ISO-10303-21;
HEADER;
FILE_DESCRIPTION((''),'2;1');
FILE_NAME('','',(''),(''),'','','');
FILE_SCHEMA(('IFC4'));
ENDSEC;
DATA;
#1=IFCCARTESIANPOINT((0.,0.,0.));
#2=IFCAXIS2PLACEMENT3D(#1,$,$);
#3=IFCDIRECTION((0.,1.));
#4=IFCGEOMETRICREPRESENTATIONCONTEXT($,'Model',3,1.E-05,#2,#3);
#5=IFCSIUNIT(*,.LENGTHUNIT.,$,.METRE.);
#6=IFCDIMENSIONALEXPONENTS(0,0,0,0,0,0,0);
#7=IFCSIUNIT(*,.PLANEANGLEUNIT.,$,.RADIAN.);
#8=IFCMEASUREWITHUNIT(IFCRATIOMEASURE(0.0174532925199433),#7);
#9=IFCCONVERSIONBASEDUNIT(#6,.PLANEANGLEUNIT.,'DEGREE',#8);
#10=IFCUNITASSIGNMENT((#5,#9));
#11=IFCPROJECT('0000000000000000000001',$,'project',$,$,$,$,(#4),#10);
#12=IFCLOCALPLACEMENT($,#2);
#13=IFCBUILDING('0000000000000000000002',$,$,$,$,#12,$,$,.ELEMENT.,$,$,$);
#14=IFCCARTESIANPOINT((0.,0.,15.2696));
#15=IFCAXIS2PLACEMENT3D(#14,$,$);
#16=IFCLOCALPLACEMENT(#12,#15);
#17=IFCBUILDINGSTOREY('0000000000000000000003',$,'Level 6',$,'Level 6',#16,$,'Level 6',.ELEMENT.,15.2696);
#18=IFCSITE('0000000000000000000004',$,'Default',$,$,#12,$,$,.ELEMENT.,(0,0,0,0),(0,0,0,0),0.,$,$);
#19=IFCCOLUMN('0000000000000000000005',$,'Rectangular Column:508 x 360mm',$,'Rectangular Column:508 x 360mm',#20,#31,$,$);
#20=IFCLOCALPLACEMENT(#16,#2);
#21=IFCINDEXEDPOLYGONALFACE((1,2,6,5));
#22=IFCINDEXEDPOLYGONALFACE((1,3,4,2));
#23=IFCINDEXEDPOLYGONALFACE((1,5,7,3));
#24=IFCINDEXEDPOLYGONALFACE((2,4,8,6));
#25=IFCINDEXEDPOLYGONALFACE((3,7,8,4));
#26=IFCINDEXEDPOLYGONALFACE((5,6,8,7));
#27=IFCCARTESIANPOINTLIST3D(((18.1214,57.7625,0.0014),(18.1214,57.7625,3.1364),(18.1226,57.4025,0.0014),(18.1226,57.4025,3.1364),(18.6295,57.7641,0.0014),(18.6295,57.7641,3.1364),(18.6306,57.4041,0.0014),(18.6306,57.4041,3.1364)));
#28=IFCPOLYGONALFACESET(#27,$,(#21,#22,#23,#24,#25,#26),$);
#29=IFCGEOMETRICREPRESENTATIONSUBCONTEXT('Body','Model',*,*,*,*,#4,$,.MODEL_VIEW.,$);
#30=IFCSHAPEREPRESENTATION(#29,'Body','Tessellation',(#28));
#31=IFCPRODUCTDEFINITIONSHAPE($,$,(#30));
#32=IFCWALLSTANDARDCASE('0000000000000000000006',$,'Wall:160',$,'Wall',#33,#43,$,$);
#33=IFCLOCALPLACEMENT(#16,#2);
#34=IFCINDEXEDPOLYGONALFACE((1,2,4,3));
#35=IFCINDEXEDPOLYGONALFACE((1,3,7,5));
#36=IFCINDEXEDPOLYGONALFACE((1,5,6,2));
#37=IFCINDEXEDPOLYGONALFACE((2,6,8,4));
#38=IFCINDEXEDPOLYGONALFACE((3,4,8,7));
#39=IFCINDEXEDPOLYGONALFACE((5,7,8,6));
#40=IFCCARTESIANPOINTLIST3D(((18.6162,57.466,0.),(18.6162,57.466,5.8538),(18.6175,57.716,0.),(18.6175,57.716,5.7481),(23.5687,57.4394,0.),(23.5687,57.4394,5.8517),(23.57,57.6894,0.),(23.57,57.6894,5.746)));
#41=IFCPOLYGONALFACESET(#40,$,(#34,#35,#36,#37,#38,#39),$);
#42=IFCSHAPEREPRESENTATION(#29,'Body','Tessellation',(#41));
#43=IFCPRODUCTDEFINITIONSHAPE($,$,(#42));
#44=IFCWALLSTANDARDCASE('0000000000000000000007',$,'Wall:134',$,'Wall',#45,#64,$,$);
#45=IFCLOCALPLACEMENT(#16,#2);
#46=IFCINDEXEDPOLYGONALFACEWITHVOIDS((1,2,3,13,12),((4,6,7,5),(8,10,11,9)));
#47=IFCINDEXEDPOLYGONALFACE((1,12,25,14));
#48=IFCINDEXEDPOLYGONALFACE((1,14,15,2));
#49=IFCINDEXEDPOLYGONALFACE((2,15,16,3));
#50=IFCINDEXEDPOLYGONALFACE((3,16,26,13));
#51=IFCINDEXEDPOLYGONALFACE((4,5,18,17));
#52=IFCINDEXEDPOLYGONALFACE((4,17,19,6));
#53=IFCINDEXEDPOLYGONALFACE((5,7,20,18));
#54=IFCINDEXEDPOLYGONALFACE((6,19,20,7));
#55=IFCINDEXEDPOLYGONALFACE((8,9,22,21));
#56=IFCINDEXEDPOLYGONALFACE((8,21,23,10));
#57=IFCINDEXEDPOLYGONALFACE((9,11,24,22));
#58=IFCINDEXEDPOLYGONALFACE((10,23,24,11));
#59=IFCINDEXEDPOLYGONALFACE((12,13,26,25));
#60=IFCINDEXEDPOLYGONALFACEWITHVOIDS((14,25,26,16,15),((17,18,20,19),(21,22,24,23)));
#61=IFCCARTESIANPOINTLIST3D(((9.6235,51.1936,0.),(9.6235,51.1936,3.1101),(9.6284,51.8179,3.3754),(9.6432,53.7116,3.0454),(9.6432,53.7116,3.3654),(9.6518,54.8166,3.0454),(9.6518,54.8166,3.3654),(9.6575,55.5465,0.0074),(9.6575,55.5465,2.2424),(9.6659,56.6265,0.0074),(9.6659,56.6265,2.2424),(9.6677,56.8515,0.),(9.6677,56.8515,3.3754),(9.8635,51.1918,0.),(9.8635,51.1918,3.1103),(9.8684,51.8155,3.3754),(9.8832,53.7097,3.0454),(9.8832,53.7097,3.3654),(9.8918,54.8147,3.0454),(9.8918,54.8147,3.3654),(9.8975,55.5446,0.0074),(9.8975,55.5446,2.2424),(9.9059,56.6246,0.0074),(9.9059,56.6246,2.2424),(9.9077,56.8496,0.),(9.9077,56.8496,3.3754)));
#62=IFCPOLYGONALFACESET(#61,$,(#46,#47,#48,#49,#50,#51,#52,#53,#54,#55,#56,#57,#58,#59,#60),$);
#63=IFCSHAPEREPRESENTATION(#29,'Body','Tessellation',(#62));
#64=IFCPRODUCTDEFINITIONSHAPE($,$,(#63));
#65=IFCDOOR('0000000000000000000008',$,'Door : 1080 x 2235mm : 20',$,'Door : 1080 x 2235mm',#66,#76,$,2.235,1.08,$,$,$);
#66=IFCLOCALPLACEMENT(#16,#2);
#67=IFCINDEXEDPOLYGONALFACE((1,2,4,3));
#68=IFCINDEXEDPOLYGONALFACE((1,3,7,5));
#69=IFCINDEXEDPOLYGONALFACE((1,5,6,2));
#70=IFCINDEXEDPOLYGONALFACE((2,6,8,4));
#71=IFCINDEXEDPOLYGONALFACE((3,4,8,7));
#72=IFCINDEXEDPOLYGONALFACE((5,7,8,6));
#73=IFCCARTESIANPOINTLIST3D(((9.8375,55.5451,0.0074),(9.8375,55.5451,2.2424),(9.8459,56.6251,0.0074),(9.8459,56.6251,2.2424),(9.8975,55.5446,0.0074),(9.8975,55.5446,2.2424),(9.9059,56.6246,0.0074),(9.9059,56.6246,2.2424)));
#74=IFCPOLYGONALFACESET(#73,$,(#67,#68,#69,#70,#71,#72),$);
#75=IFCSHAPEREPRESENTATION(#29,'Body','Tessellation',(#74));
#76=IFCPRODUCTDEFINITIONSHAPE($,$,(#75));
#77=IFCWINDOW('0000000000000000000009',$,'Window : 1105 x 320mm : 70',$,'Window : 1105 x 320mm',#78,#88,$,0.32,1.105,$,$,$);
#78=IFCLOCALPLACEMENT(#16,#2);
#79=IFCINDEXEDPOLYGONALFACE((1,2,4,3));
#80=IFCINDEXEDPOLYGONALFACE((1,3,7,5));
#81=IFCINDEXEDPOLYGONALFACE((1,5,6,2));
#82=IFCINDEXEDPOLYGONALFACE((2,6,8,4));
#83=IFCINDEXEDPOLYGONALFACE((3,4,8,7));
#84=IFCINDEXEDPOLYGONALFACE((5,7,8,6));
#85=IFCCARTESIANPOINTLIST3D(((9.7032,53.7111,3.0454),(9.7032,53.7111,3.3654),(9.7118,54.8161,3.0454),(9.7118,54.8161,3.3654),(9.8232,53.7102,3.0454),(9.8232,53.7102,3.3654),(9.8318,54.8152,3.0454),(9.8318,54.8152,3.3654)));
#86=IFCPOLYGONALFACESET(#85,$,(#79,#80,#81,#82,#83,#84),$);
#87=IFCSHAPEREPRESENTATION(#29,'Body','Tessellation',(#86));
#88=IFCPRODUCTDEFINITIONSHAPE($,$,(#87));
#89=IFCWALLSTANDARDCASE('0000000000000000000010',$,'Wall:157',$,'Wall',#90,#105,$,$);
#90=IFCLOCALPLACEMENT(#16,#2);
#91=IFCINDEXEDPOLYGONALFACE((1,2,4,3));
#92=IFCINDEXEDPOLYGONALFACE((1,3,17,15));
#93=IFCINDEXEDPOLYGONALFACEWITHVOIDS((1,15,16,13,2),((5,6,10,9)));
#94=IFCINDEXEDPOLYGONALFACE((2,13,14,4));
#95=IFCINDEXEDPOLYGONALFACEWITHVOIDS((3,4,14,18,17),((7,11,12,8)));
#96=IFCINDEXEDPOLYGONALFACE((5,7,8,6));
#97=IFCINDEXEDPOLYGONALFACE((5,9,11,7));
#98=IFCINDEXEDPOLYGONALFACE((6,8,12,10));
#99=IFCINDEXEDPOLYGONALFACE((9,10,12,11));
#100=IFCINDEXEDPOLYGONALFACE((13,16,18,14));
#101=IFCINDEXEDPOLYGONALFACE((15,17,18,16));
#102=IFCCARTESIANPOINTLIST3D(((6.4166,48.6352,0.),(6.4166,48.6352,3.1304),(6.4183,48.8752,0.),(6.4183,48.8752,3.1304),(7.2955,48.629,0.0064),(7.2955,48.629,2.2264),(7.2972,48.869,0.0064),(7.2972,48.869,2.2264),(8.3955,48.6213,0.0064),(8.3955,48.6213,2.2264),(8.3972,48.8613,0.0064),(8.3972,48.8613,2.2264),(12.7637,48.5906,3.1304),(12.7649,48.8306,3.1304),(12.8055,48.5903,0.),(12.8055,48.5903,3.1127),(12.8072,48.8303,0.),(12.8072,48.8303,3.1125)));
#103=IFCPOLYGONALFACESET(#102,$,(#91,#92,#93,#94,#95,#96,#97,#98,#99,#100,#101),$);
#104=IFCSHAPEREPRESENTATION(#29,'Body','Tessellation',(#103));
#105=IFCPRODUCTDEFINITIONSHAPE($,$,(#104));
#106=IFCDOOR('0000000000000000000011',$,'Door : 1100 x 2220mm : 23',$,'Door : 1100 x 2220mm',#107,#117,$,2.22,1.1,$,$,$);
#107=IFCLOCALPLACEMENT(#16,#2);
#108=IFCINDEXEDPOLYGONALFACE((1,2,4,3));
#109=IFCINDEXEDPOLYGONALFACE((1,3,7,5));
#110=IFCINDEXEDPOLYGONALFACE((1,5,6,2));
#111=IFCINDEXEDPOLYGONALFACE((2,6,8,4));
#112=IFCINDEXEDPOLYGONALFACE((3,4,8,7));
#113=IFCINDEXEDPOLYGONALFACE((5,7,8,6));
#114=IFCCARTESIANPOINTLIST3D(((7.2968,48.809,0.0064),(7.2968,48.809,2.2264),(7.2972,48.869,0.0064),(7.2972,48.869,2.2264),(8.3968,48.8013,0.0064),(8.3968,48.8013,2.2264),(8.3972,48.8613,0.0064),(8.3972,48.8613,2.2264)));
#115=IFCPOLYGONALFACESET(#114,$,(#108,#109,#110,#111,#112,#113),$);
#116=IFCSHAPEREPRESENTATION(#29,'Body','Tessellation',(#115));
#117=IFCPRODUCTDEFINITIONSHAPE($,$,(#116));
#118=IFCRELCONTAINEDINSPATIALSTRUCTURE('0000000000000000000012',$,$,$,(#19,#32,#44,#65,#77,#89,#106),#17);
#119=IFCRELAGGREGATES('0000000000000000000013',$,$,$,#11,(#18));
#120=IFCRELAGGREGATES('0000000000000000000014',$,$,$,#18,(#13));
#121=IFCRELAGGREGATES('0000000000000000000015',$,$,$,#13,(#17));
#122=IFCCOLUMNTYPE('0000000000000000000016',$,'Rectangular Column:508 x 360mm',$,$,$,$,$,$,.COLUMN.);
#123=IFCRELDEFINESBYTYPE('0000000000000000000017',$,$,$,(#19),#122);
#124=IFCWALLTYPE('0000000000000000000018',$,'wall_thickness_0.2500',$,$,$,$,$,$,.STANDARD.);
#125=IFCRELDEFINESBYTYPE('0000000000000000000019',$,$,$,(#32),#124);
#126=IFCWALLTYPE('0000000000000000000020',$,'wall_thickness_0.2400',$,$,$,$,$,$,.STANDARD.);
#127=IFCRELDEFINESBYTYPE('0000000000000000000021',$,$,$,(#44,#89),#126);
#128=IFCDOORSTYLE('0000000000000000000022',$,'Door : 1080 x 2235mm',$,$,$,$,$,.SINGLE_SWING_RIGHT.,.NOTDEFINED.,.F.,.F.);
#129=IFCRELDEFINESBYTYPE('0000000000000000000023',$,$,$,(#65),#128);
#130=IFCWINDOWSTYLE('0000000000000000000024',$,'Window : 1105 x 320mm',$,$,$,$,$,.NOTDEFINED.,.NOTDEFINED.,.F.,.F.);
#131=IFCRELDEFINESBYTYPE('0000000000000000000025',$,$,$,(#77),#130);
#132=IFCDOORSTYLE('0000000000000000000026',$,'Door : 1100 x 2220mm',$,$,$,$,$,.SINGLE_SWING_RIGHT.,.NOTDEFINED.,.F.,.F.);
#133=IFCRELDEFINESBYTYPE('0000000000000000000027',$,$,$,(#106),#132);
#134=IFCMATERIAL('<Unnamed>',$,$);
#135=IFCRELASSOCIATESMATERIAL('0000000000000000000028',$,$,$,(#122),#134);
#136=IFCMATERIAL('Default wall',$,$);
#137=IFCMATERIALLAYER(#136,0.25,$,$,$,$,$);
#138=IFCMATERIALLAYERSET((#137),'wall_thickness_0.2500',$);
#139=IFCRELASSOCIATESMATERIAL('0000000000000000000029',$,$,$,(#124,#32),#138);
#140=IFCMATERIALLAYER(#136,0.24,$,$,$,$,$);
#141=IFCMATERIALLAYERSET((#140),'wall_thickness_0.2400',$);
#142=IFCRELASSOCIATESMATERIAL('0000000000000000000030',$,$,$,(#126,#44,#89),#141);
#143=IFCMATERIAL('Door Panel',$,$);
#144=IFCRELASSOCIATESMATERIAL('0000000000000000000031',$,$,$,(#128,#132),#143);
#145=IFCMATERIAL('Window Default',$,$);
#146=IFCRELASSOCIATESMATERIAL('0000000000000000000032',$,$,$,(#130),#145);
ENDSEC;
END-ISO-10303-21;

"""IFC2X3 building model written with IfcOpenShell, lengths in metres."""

from ifc_helpers import new_model, entity, si_unit, converted_unit, direction, frame, frame_2d, origin, origin_2d_with_axis, place, context, subcontext, project, spatial, polyline, rectangle, outline, extrude, clip, halfspace, source, transform, mapped, material, layer, layer_set, layer_usage, type_object, type_shapes, element, fill, save


model = new_model("IFC2X3")

# Units and contexts
model_context = context("Model", 3, precision=1e-05, world=origin(), true_north=direction((0.0, 1.0)))
body_context = subcontext(model_context, "Body", "Model", "MODEL_VIEW")
ifc_project = project(units=[si_unit("LENGTHUNIT", "METRE"), converted_unit("PLANEANGLEUNIT", "DEGREE", entity("IfcRatioMeasure", 0.0174532925199433), si_unit("PLANEANGLEUNIT", "RADIAN"), dimensions=[0, 0, 0, 0, 0, 0, 0])], contexts=[model_context])

# Site, building, storey
placement = place(None, origin())
site = spatial("IfcSite", under=ifc_project, at=placement, Name="Default", CompositionType="ELEMENT", RefLatitude=(0, 0, 0, 0), RefLongitude=(0, 0, 0, 0), RefElevation=0.0)
building = spatial("IfcBuilding", under=site, at=placement, CompositionType="ELEMENT")
storey_placement = place(placement, frame((0.0, 0.0, 15.2696)))
storey = spatial("IfcBuildingStorey", under=building, at=storey_placement, Name="Level 6", ObjectType="Level 6", LongName="Level 6", CompositionType="ELEMENT", Elevation=15.2696)

# Column
ifc_material_1 = material(Name="<Unnamed>")
column_type = type_object("IfcColumnType", Name="Rectangular Column:508 x 360mm", PredefinedType="COLUMN", material=ifc_material_1)
shared_shape_1 = source(origin(), body_context, "Body", "SweptSolid", [
    extrude(rectangle(XDim=0.508, YDim=0.36, at=origin_2d_with_axis()), frame((0.0, 0.0, 0.0), z_axis=(0.0, 0.0, 1.0), x_axis=(0.0, -1.0, 0.0)), (0.0, 0.0, 1.0), 3.135),
])
type_shapes(column_type, [shared_shape_1])
column_placement = place(placement, frame((18.376, 57.5833, 15.271), z_axis=(0.0, 0.0, 1.0), x_axis=(0.003112, -0.999995, 0.0)))
element("IfcColumn", 1, at=column_placement, inside=storey, type_object=column_type, Name="Rectangular Column:508 x 360mm", ObjectType="Rectangular Column:508 x 360mm", context=body_context, shape_type="MappedRepresentation", body=[
    mapped(shared_shape_1, transform((0.0, 0.0, 0.0), scale=1.0)),
])

# Wall
ifc_material_2 = material(Name="Default wall")
ifc_layer_1 = layer(ifc_material_2, 0.25)
ifc_layer_set_1 = layer_set([ifc_layer_1], Name="wall_thickness_0.2500")
ifc_layer_usage_1 = layer_usage(ifc_layer_set_1, "AXIS2", "POSITIVE", -0.125)
wall_type_1 = type_object("IfcWallType", Name="wall_thickness_0.2500", PredefinedType="STANDARD", material=ifc_layer_set_1)
wall_1_placement = place(storey_placement, frame((18.6169, 57.591, 0.0), z_axis=(0.0, 0.0, 1.0), x_axis=(0.999986, -0.005353, 0.0)))
element("IfcWallStandardCase", 2, at=wall_1_placement, inside=storey, type_object=wall_type_1, material=ifc_layer_usage_1, Name="Wall:160", ObjectType="Wall", context=body_context, shape_type="Clipping", body=[
    clip(extrude(outline(polyline([(4.9525, -0.125), (4.9525, 0.125), (0.0, 0.125), (0.0, -0.125), (4.9525, -0.125)])), origin(), (0.0, 0.0, 1.0), 6.0254), halfspace(frame((6.0103, -0.0562, 5.8222), z_axis=(0.000388, 0.389455, 0.921045), x_axis=(-0.999996, 0.002797, -0.000761)), False)),
])

# Wall, openings, door, window
ifc_layer_2 = layer(ifc_material_2, 0.24)
ifc_layer_set_2 = layer_set([ifc_layer_2], Name="wall_thickness_0.2400")
ifc_layer_usage_2 = layer_usage(ifc_layer_set_2, "AXIS2", "POSITIVE", -0.12)
wall_type_2 = type_object("IfcWallType", Name="wall_thickness_0.2400", PredefinedType="STANDARD", material=ifc_layer_set_2)
wall_2_placement = place(storey_placement, frame((9.7877, 56.8505, 0.0), z_axis=(0.0, 0.0, 1.0), x_axis=(-0.007798, -0.99997, 0.0)))
wall_2 = element("IfcWallStandardCase", 3, at=wall_2_placement, inside=storey, type_object=wall_type_2, material=ifc_layer_usage_2, Name="Wall:134", ObjectType="Wall", context=body_context, shape_type="Clipping", body=[
    clip(clip(extrude(outline(polyline([(5.658, -0.12), (5.658, 0.12), (0.0, 0.12), (0.0, -0.12), (5.658, -0.12)])), origin(), (0.0, 0.0, 1.0), 3.3754), halfspace(frame((-0.7809, -22.5476, 5.8261), z_axis=(0.391129, -0.000838, 0.920336), x_axis=(0.000352, 1.0, 0.000761)), False)), halfspace(frame((-20.4091, 2.8698, 3.1673), z_axis=(-0.001142, 0.390498, 0.920603), x_axis=(0.675569, -0.678456, 0.288623)), False)),
])
opening_1_placement = place(wall_2_placement, frame((0.225, -0.12, 0.0074)))
opening_1 = element("IfcOpeningElement", 4, at=opening_1_placement, cuts=wall_2, ObjectType="Opening", context=body_context, shape_type="SweptSolid", body=[
    extrude(rectangle(XDim=1.08, YDim=2.235, at=frame_2d((1.1175, 0.54), x_axis=(0.0, 1.0))), frame((0.0, 0.0, 0.0), z_axis=(0.0, 1.0, 0.0), x_axis=(0.0, 0.0, 1.0)), (0.0, 0.0, 1.0), 0.24),
])
opening_2_placement = place(wall_2_placement, frame((2.035, -0.12, 3.0454)))
opening_2 = element("IfcOpeningElement", 5, at=opening_2_placement, cuts=wall_2, ObjectType="Opening", context=body_context, shape_type="SweptSolid", body=[
    extrude(rectangle(XDim=1.105, YDim=0.32, at=frame_2d((0.16, 0.5525), x_axis=(0.0, 1.0))), frame((0.0, 0.0, 0.0), z_axis=(0.0, 1.0, 0.0), x_axis=(0.0, 0.0, 1.0)), (0.0, 0.0, 1.0), 0.24),
])
ifc_material_3 = material(Name="Door Panel")
door_style_1 = type_object("IfcDoorStyle", Name="Door : 1080 x 2235mm", ConstructionType="NOTDEFINED", OperationType="SINGLE_SWING_RIGHT", ParameterTakesPrecedence=False, Sizeable=False, material=ifc_material_3)
shared_shape_2 = source(origin(), body_context, "Body", "SweptSolid", [
    extrude(rectangle(XDim=0.06, YDim=1.08, at=origin_2d_with_axis()), frame((0.54, 0.21, 0.0), z_axis=(0.0, 0.0, 1.0), x_axis=(0.0, 1.0, 0.0)), (0.0, 0.0, 1.0), 2.235),
])
type_shapes(door_style_1, [shared_shape_2])
door_1_placement = place(opening_1_placement, origin())
door_1 = element("IfcDoor", 6, at=door_1_placement, inside=storey, type_object=door_style_1, Name="Door : 1080 x 2235mm : 20", ObjectType="Door : 1080 x 2235mm", OverallHeight=2.235, OverallWidth=1.08, context=body_context, shape_type="MappedRepresentation", body=[
    mapped(shared_shape_2, transform((0.0, 0.0, 0.0), scale=1.0)),
])
fill(opening_1, door_1)
ifc_material_4 = material(Name="Window Default")
window_style_1 = type_object("IfcWindowStyle", Name="Window : 1105 x 320mm", ConstructionType="NOTDEFINED", OperationType="NOTDEFINED", ParameterTakesPrecedence=False, Sizeable=False, material=ifc_material_4)
shared_shape_3 = source(origin(), body_context, "Body", "SweptSolid", [
    extrude(rectangle(XDim=0.12, YDim=1.105, at=origin_2d_with_axis()), frame((0.5525, 0.12, 0.0), z_axis=(0.0, 0.0, 1.0), x_axis=(0.0, 1.0, 0.0)), (0.0, 0.0, 1.0), 0.32),
])
type_shapes(window_style_1, [shared_shape_3])
window_1_placement = place(opening_2_placement, origin())
window_1 = element("IfcWindow", 7, at=window_1_placement, inside=storey, type_object=window_style_1, Name="Window : 1105 x 320mm : 70", ObjectType="Window : 1105 x 320mm", OverallHeight=0.32, OverallWidth=1.105, context=body_context, shape_type="MappedRepresentation", body=[
    mapped(shared_shape_3, transform((0.0, 0.0, 0.0), scale=1.0)),
])
fill(opening_2, window_1)

# Wall, opening, door
wall_3_placement = place(storey_placement, frame((6.4174, 48.7552, 0.0), z_axis=(0.0, 0.0, 1.0), x_axis=(0.999975, -0.007028, 0.0)))
wall_3 = element("IfcWallStandardCase", 8, at=wall_3_placement, inside=storey, type_object=wall_type_2, material=ifc_layer_usage_2, Name="Wall:157", ObjectType="Wall", context=body_context, shape_type="Clipping", body=[
    clip(extrude(outline(polyline([(6.3891, -0.12), (6.3891, 0.12), (0.0, 0.12), (0.0, -0.12), (6.3891, -0.12)])), origin(), (0.0, 0.0, 1.0), 3.1304), halfspace(frame((6.1988, 28.5257, 3.1673), z_axis=(0.390499, 0.000841, 0.920603), x_axis=(-0.678976, -0.675046, 0.288623)), False)),
])
opening_3_placement = place(wall_3_placement, frame((0.879, -0.12, 0.0064)))
opening_3 = element("IfcOpeningElement", 9, at=opening_3_placement, cuts=wall_3, ObjectType="Opening", context=body_context, shape_type="SweptSolid", body=[
    extrude(rectangle(XDim=1.1, YDim=2.22, at=frame_2d((1.11, 0.55), x_axis=(0.0, 1.0))), frame((0.0, 0.0, 0.0), z_axis=(0.0, 1.0, 0.0), x_axis=(0.0, 0.0, 1.0)), (0.0, 0.0, 1.0), 0.24),
])
door_style_2 = type_object("IfcDoorStyle", Name="Door : 1100 x 2220mm", ConstructionType="NOTDEFINED", OperationType="SINGLE_SWING_RIGHT", ParameterTakesPrecedence=False, Sizeable=False, material=ifc_material_3)
shared_shape_4 = source(origin(), body_context, "Body", "SweptSolid", [
    extrude(rectangle(XDim=0.06, YDim=1.1, at=origin_2d_with_axis()), frame((0.55, 0.21, 0.0), z_axis=(0.0, 0.0, 1.0), x_axis=(0.0, 1.0, 0.0)), (0.0, 0.0, 1.0), 2.22),
])
type_shapes(door_style_2, [shared_shape_4])
door_2_placement = place(opening_3_placement, origin())
door_2 = element("IfcDoor", 10, at=door_2_placement, inside=storey, type_object=door_style_2, Name="Door : 1100 x 2220mm : 23", ObjectType="Door : 1100 x 2220mm", OverallHeight=2.22, OverallWidth=1.1, context=body_context, shape_type="MappedRepresentation", body=[
    mapped(shared_shape_4, transform((0.0, 0.0, 0.0), scale=1.0)),
])
fill(opening_3, door_2)

save(model, "model.ifc")
